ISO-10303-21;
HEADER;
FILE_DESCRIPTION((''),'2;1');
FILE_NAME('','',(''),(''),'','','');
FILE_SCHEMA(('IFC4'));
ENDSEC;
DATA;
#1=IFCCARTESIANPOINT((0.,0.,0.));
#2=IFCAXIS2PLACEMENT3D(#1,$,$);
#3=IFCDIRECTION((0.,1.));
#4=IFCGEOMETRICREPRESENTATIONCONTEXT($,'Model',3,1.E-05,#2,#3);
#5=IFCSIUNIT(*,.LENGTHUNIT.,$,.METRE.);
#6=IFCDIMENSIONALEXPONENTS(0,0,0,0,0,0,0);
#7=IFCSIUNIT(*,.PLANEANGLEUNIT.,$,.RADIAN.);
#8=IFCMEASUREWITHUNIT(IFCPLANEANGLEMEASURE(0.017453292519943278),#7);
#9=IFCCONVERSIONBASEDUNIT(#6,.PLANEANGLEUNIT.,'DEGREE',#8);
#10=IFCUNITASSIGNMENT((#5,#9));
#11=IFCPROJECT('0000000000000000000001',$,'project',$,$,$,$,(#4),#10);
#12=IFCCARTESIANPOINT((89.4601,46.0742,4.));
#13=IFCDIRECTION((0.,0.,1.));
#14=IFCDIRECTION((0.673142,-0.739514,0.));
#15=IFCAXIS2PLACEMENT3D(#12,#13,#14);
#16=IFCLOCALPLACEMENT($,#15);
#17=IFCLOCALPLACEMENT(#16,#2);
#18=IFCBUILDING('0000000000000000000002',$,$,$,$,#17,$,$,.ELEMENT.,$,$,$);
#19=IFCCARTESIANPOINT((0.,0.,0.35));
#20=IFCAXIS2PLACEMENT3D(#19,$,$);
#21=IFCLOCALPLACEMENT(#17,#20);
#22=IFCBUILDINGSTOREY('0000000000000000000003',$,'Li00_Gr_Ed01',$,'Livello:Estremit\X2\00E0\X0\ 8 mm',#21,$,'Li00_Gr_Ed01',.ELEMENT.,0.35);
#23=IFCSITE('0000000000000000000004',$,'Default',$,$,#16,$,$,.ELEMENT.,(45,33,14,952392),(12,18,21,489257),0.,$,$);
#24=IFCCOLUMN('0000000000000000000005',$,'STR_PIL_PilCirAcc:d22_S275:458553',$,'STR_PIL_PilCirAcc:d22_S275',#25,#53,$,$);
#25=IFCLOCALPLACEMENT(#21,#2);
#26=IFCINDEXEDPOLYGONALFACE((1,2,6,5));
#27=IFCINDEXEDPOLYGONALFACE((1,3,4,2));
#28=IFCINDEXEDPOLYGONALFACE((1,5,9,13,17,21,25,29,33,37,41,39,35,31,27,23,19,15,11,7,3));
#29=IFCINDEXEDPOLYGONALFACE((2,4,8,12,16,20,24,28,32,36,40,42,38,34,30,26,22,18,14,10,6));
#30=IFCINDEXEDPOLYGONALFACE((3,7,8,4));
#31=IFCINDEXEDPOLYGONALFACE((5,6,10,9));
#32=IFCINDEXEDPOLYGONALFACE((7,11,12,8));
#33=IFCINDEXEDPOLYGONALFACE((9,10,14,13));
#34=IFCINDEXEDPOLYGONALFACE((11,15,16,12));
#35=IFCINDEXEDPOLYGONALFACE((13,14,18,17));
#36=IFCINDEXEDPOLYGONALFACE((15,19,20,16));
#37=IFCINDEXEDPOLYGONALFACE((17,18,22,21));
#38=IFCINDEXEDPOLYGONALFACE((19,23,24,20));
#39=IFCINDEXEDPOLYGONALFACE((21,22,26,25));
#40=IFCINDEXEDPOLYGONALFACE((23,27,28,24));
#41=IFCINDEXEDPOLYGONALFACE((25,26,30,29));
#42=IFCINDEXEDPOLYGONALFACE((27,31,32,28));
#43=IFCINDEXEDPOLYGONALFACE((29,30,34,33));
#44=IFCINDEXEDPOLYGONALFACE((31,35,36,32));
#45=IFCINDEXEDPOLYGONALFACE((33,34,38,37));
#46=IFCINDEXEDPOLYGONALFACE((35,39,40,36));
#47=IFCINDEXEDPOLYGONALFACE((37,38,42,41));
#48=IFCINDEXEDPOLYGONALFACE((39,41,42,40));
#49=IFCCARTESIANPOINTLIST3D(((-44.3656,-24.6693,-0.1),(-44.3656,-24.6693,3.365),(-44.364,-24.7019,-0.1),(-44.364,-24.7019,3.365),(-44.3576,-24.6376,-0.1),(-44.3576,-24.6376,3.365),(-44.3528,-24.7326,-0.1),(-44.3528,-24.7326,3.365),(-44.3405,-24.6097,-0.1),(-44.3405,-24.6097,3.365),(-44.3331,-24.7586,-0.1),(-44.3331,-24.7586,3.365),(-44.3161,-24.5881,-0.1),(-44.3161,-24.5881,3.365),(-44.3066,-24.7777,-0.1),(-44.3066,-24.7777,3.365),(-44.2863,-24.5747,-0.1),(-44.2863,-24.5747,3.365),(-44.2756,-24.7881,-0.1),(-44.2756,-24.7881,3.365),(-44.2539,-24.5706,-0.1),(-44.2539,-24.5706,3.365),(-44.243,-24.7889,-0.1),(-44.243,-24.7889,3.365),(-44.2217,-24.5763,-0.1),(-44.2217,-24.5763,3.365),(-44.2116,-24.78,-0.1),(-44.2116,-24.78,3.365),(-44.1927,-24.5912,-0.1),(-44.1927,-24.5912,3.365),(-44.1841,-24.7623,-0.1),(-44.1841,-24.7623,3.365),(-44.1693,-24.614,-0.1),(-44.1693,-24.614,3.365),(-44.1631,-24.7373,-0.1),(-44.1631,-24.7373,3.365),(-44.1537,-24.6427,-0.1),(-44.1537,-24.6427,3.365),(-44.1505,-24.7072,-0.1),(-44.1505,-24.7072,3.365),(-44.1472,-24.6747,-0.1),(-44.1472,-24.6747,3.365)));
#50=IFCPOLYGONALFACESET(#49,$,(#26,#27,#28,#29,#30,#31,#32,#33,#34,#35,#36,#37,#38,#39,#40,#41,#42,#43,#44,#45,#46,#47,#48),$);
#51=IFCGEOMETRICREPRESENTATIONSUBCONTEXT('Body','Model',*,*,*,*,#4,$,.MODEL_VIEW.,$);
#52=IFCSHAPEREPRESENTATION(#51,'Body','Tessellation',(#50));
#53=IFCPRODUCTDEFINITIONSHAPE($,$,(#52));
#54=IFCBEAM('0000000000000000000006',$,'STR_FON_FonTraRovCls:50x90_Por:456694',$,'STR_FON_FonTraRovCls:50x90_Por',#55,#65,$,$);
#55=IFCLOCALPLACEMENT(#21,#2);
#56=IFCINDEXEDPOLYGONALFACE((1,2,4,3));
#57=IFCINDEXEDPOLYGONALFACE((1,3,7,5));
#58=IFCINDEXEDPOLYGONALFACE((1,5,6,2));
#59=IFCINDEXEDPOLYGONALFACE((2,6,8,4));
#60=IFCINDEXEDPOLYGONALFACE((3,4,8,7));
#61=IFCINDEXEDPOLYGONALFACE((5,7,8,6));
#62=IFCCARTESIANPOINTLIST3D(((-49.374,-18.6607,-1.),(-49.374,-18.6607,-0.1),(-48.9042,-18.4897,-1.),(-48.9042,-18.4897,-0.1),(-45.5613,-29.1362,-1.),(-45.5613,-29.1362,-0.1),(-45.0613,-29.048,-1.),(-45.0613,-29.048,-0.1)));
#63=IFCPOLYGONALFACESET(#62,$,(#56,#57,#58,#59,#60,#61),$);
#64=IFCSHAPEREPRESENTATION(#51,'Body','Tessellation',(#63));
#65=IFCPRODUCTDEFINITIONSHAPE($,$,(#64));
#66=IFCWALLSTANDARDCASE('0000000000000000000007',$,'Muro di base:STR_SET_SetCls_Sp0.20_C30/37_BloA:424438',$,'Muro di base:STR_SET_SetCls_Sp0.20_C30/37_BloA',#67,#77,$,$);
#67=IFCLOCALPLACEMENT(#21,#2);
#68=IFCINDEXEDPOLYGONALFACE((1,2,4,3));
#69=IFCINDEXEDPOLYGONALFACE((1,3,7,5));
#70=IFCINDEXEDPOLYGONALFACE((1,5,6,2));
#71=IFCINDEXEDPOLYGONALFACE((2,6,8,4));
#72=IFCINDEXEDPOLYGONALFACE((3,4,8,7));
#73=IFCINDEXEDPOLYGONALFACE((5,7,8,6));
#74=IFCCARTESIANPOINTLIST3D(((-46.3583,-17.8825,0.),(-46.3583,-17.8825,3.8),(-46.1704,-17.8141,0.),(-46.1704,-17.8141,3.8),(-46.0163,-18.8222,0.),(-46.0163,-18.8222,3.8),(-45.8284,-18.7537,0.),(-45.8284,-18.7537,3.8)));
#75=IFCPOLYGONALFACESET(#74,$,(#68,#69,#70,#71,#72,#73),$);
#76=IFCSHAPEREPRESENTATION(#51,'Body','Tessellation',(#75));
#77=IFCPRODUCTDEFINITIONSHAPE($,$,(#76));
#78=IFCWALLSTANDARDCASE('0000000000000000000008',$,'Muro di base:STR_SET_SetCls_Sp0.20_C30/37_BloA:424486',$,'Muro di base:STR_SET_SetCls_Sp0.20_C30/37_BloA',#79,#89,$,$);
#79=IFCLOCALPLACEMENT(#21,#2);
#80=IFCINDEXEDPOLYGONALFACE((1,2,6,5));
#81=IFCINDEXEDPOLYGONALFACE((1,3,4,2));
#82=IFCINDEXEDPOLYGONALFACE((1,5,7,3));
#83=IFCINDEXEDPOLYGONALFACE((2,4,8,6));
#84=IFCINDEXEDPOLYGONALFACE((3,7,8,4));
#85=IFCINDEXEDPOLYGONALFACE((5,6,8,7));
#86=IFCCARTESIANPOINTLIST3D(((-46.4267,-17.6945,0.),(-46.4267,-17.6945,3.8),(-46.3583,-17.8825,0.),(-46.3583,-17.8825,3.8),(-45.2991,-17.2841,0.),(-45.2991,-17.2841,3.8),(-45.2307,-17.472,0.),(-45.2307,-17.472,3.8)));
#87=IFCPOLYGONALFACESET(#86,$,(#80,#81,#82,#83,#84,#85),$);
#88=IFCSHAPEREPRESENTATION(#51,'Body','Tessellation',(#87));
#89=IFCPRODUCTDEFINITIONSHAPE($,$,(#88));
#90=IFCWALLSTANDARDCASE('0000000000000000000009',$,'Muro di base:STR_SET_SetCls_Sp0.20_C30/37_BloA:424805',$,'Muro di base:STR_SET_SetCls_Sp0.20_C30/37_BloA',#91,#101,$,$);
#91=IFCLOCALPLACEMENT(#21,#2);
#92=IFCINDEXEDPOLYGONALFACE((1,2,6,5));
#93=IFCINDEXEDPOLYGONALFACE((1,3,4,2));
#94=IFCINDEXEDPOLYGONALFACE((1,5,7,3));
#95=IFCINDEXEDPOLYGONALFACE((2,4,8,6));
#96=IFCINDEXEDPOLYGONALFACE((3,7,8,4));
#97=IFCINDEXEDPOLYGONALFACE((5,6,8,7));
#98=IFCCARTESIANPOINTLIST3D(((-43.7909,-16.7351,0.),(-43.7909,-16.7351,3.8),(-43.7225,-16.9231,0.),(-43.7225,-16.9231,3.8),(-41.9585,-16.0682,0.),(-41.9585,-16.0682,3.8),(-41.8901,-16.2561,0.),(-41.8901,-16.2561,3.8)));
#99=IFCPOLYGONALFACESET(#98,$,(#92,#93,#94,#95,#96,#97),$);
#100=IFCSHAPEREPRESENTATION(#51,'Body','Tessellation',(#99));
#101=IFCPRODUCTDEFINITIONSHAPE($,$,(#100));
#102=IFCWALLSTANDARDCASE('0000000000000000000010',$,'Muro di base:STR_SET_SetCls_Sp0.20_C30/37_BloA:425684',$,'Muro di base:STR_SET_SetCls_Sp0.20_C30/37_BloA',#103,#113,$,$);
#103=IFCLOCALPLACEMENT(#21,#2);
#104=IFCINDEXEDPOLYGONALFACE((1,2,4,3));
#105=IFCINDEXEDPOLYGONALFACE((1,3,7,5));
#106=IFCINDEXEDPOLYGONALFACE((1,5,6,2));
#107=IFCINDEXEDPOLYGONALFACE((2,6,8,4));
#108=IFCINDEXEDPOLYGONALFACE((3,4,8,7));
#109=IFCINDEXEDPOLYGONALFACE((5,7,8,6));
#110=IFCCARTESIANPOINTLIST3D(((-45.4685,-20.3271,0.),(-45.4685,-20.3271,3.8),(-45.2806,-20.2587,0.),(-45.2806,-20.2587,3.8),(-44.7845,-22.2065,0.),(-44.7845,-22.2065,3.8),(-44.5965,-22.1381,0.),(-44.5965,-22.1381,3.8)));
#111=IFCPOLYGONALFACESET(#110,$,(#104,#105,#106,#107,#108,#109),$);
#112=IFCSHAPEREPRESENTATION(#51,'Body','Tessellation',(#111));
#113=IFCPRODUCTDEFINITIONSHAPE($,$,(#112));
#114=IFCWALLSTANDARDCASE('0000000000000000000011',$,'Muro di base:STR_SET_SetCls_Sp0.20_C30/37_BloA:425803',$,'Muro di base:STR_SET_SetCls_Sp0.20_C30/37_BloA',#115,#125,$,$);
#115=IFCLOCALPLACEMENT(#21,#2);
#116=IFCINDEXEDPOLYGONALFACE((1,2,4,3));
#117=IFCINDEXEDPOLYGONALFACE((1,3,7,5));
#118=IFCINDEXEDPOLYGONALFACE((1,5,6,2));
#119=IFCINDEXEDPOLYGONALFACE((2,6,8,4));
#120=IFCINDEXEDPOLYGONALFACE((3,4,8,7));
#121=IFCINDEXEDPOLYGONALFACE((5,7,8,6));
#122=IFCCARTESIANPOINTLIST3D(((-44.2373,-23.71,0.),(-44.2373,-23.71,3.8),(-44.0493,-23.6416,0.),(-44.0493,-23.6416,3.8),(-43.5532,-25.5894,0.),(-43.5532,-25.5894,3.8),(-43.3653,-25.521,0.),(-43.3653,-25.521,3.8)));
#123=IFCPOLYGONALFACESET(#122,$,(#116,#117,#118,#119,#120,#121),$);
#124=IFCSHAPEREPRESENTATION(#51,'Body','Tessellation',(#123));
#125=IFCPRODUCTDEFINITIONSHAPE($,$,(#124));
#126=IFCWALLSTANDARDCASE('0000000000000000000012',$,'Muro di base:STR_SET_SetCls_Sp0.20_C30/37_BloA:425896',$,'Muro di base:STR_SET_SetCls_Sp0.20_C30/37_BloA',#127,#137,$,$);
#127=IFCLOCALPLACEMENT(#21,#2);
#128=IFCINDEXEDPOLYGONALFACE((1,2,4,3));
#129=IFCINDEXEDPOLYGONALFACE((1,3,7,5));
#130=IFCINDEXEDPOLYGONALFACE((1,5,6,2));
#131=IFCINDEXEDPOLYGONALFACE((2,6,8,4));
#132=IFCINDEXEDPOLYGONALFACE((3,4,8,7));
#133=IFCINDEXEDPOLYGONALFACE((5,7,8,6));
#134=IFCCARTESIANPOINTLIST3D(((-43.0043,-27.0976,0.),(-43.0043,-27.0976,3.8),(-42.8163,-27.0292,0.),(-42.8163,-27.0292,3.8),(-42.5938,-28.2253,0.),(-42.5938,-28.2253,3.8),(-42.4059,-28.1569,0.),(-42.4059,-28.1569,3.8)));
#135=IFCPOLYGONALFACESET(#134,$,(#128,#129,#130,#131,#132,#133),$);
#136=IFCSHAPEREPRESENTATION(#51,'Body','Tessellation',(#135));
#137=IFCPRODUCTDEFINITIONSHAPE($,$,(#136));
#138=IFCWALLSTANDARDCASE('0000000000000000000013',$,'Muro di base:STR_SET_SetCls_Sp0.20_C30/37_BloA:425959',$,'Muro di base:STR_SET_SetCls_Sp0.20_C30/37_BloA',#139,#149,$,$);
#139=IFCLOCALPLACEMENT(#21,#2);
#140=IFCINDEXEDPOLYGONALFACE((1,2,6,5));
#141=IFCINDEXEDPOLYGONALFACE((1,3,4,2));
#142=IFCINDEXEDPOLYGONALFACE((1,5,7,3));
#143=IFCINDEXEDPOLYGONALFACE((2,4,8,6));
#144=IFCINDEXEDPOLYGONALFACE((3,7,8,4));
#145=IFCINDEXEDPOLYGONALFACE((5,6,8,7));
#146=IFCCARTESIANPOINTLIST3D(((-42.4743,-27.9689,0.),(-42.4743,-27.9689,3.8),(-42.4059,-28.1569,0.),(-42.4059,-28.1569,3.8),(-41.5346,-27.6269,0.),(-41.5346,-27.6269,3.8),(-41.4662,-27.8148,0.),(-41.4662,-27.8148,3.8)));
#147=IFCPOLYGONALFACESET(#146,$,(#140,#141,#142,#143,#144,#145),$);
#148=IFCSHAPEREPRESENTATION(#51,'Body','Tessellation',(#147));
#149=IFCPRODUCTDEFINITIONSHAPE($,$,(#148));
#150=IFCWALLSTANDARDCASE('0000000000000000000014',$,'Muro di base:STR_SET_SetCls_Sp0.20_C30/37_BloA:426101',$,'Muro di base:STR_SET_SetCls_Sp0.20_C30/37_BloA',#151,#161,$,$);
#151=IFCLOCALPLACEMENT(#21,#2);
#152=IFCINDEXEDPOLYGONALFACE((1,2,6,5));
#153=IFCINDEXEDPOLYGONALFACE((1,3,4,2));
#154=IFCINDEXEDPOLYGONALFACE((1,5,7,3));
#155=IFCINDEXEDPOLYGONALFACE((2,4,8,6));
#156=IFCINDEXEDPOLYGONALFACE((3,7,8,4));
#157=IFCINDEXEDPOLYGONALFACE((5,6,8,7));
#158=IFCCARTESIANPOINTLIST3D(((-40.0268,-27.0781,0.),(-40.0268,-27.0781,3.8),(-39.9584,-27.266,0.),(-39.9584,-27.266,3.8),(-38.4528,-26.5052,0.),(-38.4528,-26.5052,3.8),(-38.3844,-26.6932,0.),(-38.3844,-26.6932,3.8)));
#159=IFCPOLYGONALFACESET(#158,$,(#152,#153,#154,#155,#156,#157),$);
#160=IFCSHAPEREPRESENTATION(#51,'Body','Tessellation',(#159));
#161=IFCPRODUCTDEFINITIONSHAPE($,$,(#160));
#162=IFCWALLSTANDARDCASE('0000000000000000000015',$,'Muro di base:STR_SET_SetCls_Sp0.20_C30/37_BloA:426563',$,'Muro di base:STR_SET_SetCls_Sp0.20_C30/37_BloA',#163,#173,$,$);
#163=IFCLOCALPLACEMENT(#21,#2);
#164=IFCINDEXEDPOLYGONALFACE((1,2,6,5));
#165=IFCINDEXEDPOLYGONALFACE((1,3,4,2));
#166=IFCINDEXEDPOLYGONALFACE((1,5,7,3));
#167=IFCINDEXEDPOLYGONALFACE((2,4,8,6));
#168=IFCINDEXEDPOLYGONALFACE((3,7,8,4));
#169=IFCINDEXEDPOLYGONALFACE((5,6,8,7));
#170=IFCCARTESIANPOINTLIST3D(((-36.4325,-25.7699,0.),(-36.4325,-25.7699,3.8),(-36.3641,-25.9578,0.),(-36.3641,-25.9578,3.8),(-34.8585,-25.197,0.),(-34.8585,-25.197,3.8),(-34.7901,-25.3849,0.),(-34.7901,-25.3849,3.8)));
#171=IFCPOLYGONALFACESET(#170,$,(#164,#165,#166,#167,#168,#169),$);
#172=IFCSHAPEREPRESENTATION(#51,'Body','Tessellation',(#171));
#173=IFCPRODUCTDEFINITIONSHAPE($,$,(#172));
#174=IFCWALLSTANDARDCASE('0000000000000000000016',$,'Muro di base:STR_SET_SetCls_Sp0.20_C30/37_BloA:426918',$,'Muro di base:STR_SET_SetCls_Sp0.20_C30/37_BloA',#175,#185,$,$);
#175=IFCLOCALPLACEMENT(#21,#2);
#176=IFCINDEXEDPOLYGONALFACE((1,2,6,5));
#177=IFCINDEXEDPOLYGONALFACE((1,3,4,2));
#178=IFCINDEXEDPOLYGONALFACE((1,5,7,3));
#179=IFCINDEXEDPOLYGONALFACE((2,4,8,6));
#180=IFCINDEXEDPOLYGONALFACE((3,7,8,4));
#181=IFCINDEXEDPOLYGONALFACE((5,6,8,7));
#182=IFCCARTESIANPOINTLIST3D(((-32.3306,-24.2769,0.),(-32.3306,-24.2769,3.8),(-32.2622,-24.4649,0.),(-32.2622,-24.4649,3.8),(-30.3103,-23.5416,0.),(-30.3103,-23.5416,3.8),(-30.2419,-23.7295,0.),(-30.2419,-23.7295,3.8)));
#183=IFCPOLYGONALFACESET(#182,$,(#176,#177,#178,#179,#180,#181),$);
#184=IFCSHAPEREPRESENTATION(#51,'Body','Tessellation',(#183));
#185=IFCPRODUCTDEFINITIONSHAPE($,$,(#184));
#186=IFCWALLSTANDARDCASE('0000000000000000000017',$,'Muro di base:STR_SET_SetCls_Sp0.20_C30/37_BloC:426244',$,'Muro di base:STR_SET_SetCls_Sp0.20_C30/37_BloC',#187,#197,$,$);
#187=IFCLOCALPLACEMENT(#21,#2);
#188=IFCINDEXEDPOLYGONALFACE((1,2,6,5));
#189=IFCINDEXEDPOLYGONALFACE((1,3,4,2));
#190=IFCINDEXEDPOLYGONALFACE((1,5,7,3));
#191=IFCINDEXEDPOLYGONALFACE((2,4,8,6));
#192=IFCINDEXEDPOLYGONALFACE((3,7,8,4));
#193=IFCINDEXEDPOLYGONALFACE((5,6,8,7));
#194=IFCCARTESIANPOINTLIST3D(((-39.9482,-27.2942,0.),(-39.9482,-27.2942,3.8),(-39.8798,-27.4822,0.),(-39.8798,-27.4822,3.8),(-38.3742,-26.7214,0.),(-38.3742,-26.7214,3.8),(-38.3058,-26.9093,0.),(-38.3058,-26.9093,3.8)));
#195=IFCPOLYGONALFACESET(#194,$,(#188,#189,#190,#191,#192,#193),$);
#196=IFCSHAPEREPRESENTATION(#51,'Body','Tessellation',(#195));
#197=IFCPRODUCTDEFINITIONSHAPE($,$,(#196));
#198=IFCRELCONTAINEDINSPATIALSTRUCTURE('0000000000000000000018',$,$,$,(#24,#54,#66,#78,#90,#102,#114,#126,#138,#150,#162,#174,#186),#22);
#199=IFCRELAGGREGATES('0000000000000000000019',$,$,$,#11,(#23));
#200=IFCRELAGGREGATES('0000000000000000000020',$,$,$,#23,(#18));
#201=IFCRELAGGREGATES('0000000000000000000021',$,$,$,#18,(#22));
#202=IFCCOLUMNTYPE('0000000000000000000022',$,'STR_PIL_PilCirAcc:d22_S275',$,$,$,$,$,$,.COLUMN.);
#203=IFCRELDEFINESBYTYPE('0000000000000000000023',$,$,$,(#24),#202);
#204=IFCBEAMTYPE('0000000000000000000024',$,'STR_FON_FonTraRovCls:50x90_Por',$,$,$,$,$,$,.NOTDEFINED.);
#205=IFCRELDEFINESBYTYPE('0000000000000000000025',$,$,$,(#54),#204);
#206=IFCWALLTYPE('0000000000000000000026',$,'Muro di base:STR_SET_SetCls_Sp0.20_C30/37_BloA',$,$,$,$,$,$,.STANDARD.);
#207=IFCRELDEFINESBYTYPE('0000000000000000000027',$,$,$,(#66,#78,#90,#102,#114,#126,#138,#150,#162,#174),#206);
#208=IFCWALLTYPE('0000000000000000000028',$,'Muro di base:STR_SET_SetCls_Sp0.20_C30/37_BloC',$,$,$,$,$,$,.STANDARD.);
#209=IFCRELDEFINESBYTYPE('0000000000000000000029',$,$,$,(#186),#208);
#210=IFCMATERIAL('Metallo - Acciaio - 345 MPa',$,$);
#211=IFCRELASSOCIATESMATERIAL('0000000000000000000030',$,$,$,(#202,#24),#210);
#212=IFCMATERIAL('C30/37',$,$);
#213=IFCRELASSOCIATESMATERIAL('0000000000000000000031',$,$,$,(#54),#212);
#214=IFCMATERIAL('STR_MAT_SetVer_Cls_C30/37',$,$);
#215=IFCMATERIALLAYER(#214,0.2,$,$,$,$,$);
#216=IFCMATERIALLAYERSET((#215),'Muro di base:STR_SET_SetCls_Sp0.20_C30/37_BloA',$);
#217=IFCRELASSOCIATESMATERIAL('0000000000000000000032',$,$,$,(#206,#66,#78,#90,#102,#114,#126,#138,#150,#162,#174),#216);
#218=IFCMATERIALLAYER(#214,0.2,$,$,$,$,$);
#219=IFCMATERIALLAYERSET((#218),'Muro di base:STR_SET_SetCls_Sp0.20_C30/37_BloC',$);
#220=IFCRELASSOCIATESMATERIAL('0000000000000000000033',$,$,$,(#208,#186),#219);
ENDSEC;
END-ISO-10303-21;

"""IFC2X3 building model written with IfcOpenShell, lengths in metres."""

from ifc_helpers import new_model, entity, si_unit, converted_unit, direction, frame, frame_2d, origin, place, context, subcontext, project, spatial, rectangle, circle, extrude, clip, halfspace, source, transform, mapped, material, layer, layer_set, layer_usage, type_object, type_shapes, element, save


model = new_model("IFC2X3")

# Units and contexts
model_context = context("Model", 3, precision=1e-05, world=origin(), true_north=direction((0.0, 1.0)))
body_context = subcontext(model_context, "Body", "Model", "MODEL_VIEW")
ifc_project = project(units=[si_unit("LENGTHUNIT", "METRE"), converted_unit("PLANEANGLEUNIT", "DEGREE", entity("IfcPlaneAngleMeasure", 0.017453292519943278), si_unit("PLANEANGLEUNIT", "RADIAN"), dimensions=[0, 0, 0, 0, 0, 0, 0])], contexts=[model_context])

# Site, building, storey
site_placement = place(None, frame((89.4601, 46.0742, 4.0), z_axis=(0.0, 0.0, 1.0), x_axis=(0.673142, -0.739514, 0.0)))
site = spatial("IfcSite", under=ifc_project, at=site_placement, Name="Default", CompositionType="ELEMENT", RefLatitude=(45, 33, 14, 952392), RefLongitude=(12, 18, 21, 489257), RefElevation=0.0)
building_placement = place(site_placement, origin())
building = spatial("IfcBuilding", under=site, at=building_placement, CompositionType="ELEMENT")
storey_placement = place(building_placement, frame((0.0, 0.0, 0.35)))
storey = spatial("IfcBuildingStorey", under=building, at=storey_placement, Name="Li00_Gr_Ed01", ObjectType="Livello:Estremità 8 mm", LongName="Li00_Gr_Ed01", CompositionType="ELEMENT", Elevation=0.35)

# Column
ifc_material_1 = material(Name="Metallo - Acciaio - 345 MPa")
column_type = type_object("IfcColumnType", Name="STR_PIL_PilCirAcc:d22_S275", PredefinedType="COLUMN", material=ifc_material_1)
shared_shape = source(origin(), body_context, "Body", "SweptSolid", [
    extrude(circle(Radius=0.1096, at=frame_2d((0.0, 0.0), x_axis=(1.0, 0.0))), frame((0.0, 0.0, 0.25)), (0.0, 0.0, 1.0), 3.465),
])
type_shapes(column_type, [shared_shape])
column_placement = place(storey_placement, frame((-44.2566, -24.6802, -0.35), z_axis=(0.0, 0.0, 1.0), x_axis=(0.939693, 0.34202, 0.0)))
element("IfcColumn", 1, at=column_placement, inside=storey, type_object=column_type, material=ifc_material_1, Name="STR_PIL_PilCirAcc:d22_S275:458553", ObjectType="STR_PIL_PilCirAcc:d22_S275", context=body_context, shape_type="MappedRepresentation", body=[
    mapped(shared_shape, transform((0.0, 0.0, 0.0), scale=1.0)),
])

# Beam
ifc_material_2 = material(Name="C30/37")
beam_type_1 = type_object("IfcBeamType", Name="STR_FON_FonTraRovCls:50x90_Por", PredefinedType="NOTDEFINED")
beam_1_placement = place(storey_placement, frame((-49.1348, -18.587, -0.1), z_axis=(0.0, 0.0, 1.0), x_axis=(0.34202, -0.939693, 0.0)))
element("IfcBeam", 2, at=beam_1_placement, inside=storey, type_object=beam_type_1, material=ifc_material_2, Name="STR_FON_FonTraRovCls:50x90_Por:456694", ObjectType="STR_FON_FonTraRovCls:50x90_Por", context=body_context, shape_type="SweptSolid", body=[
    clip(extrude(rectangle(XDim=0.9, YDim=0.5, at=frame_2d((0.0, 0.0), x_axis=(1.0, 0.0))), frame((-0.0125, 0.0, -0.45), z_axis=(1.0, 0.0, 0.0), x_axis=(0.0, 0.0, -1.0)), (0.0, 0.0, 1.0), 11.2359), halfspace(frame((11.1352, -0.25, 0.0), z_axis=(0.984808, -0.173648, 0.0), x_axis=(0.173648, 0.984808, 0.0)), False)),
])

# Walls
ifc_material_3 = material(Name="STR_MAT_SetVer_Cls_C30/37")
ifc_layer_1 = layer(ifc_material_3, 0.2)
ifc_layer_set_1 = layer_set([ifc_layer_1], Name="Muro di base:STR_SET_SetCls_Sp0.20_C30/37_BloA")
ifc_layer_usage_1 = layer_usage(ifc_layer_set_1, "AXIS2", "NEGATIVE", 0.1)
wall_type_1 = type_object("IfcWallType", Name="Muro di base:STR_SET_SetCls_Sp0.20_C30/37_BloA", PredefinedType="STANDARD", material=ifc_layer_set_1)
wall_1_placement = place(storey_placement, frame((-45.9223, -18.788, 0.0), z_axis=(0.0, 0.0, 1.0), x_axis=(-0.34202, 0.939693, 0.0)))
element("IfcWallStandardCase", 3, at=wall_1_placement, inside=storey, type_object=wall_type_1, material=ifc_layer_usage_1, Name="Muro di base:STR_SET_SetCls_Sp0.20_C30/37_BloA:424438", ObjectType="Muro di base:STR_SET_SetCls_Sp0.20_C30/37_BloA", context=body_context, shape_type="SweptSolid", body=[
    extrude(rectangle(XDim=1.0, YDim=0.2, at=frame_2d((0.5, 0.0), x_axis=(-1.0, 0.0))), origin(), (0.0, 0.0, 1.0), 3.8),
])
wall_2_placement = place(storey_placement, frame((-45.2649, -17.3781, 0.0), z_axis=(0.0, 0.0, 1.0), x_axis=(-0.939693, -0.34202, 0.0)))
element("IfcWallStandardCase", 4, at=wall_2_placement, inside=storey, type_object=wall_type_1, material=ifc_layer_usage_1, Name="Muro di base:STR_SET_SetCls_Sp0.20_C30/37_BloA:424486", ObjectType="Muro di base:STR_SET_SetCls_Sp0.20_C30/37_BloA", context=body_context, shape_type="SweptSolid", body=[
    extrude(rectangle(XDim=1.2, YDim=0.2, at=frame_2d((0.6, 0.0), x_axis=(-1.0, 0.0))), origin(), (0.0, 0.0, 1.0), 3.8),
])
wall_3_placement = place(storey_placement, frame((-43.7567, -16.8291, 0.0), z_axis=(0.0, 0.0, 1.0), x_axis=(0.939693, 0.34202, 0.0)))
element("IfcWallStandardCase", 5, at=wall_3_placement, inside=storey, type_object=wall_type_1, material=ifc_layer_usage_1, Name="Muro di base:STR_SET_SetCls_Sp0.20_C30/37_BloA:424805", ObjectType="Muro di base:STR_SET_SetCls_Sp0.20_C30/37_BloA", context=body_context, shape_type="SweptSolid", body=[
    extrude(rectangle(XDim=1.95, YDim=0.2, at=frame_2d((0.975, 0.0), x_axis=(-1.0, 0.0))), origin(), (0.0, 0.0, 1.0), 3.8),
])
wall_4_placement = place(storey_placement, frame((-45.3746, -20.2929, 0.0), z_axis=(0.0, 0.0, 1.0), x_axis=(0.34202, -0.939693, 0.0)))
element("IfcWallStandardCase", 6, at=wall_4_placement, inside=storey, type_object=wall_type_1, material=ifc_layer_usage_1, Name="Muro di base:STR_SET_SetCls_Sp0.20_C30/37_BloA:425684", ObjectType="Muro di base:STR_SET_SetCls_Sp0.20_C30/37_BloA", context=body_context, shape_type="SweptSolid", body=[
    extrude(rectangle(XDim=2.0, YDim=0.2, at=frame_2d((1.0, 0.0), x_axis=(-1.0, 0.0))), origin(), (0.0, 0.0, 1.0), 3.8),
])
wall_5_placement = place(storey_placement, frame((-44.1433, -23.6758, 0.0), z_axis=(0.0, 0.0, 1.0), x_axis=(0.34202, -0.939693, 0.0)))
element("IfcWallStandardCase", 7, at=wall_5_placement, inside=storey, type_object=wall_type_1, material=ifc_layer_usage_1, Name="Muro di base:STR_SET_SetCls_Sp0.20_C30/37_BloA:425803", ObjectType="Muro di base:STR_SET_SetCls_Sp0.20_C30/37_BloA", context=body_context, shape_type="SweptSolid", body=[
    extrude(rectangle(XDim=2.0, YDim=0.2, at=frame_2d((1.0, 0.0), x_axis=(-1.0, 0.0))), origin(), (0.0, 0.0, 1.0), 3.8),
])
wall_6_placement = place(storey_placement, frame((-42.9103, -27.0634, 0.0), z_axis=(0.0, 0.0, 1.0), x_axis=(0.34202, -0.939693, 0.0)))
element("IfcWallStandardCase", 8, at=wall_6_placement, inside=storey, type_object=wall_type_1, material=ifc_layer_usage_1, Name="Muro di base:STR_SET_SetCls_Sp0.20_C30/37_BloA:425896", ObjectType="Muro di base:STR_SET_SetCls_Sp0.20_C30/37_BloA", context=body_context, shape_type="SweptSolid", body=[
    extrude(rectangle(XDim=1.2, YDim=0.2, at=frame_2d((0.6, 0.0), x_axis=(-1.0, 0.0))), origin(), (0.0, 0.0, 1.0), 3.8),
])
wall_7_placement = place(storey_placement, frame((-42.4401, -28.0629, 0.0), z_axis=(0.0, 0.0, 1.0), x_axis=(0.939693, 0.34202, 0.0)))
element("IfcWallStandardCase", 9, at=wall_7_placement, inside=storey, type_object=wall_type_1, material=ifc_layer_usage_1, Name="Muro di base:STR_SET_SetCls_Sp0.20_C30/37_BloA:425959", ObjectType="Muro di base:STR_SET_SetCls_Sp0.20_C30/37_BloA", context=body_context, shape_type="SweptSolid", body=[
    extrude(rectangle(XDim=1.0, YDim=0.2, at=frame_2d((0.5, 0.0), x_axis=(-1.0, 0.0))), origin(), (0.0, 0.0, 1.0), 3.8),
])
for number, where, z_axis, x_axis, name in (
    (10, (-39.9926, -27.1721, 0.0), (0.0, 0.0, 1.0), (0.939693, 0.34202, 0.0), "Muro di base:STR_SET_SetCls_Sp0.20_C30/37_BloA:426101"),
    (11, (-36.3983, -25.8638, 0.0), (0.0, 0.0, 1.0), (0.939693, 0.34202, 0.0), "Muro di base:STR_SET_SetCls_Sp0.20_C30/37_BloA:426563"),
):
    element("IfcWallStandardCase", number, at=place(storey_placement, frame(where, z_axis=z_axis, x_axis=x_axis)), inside=storey, type_object=wall_type_1, material=ifc_layer_usage_1, Name=name, ObjectType="Muro di base:STR_SET_SetCls_Sp0.20_C30/37_BloA", context=body_context, shape_type="SweptSolid", body=[
        extrude(rectangle(XDim=1.675, YDim=0.2, at=frame_2d((0.8375, 0.0), x_axis=(-1.0, 0.0))), origin(), (0.0, 0.0, 1.0), 3.8),
    ])
wall_8_placement = place(storey_placement, frame((-32.2964, -24.3709, 0.0), z_axis=(0.0, 0.0, 1.0), x_axis=(0.939693, 0.34202, 0.0)))
element("IfcWallStandardCase", 12, at=wall_8_placement, inside=storey, type_object=wall_type_1, material=ifc_layer_usage_1, Name="Muro di base:STR_SET_SetCls_Sp0.20_C30/37_BloA:426918", ObjectType="Muro di base:STR_SET_SetCls_Sp0.20_C30/37_BloA", context=body_context, shape_type="SweptSolid", body=[
    extrude(rectangle(XDim=2.15, YDim=0.2, at=frame_2d((1.075, 0.0), x_axis=(-1.0, 0.0))), origin(), (0.0, 0.0, 1.0), 3.8),
])
ifc_layer_2 = layer(ifc_material_3, 0.2)
ifc_layer_set_2 = layer_set([ifc_layer_2], Name="Muro di base:STR_SET_SetCls_Sp0.20_C30/37_BloC")
ifc_layer_usage_2 = layer_usage(ifc_layer_set_2, "AXIS2", "NEGATIVE", 0.1)
wall_type_2 = type_object("IfcWallType", Name="Muro di base:STR_SET_SetCls_Sp0.20_C30/37_BloC", PredefinedType="STANDARD", material=ifc_layer_set_2)
wall_9_placement = place(storey_placement, frame((-39.914, -27.3882, 0.0), z_axis=(0.0, 0.0, 1.0), x_axis=(0.939693, 0.34202, 0.0)))
element("IfcWallStandardCase", 13, at=wall_9_placement, inside=storey, type_object=wall_type_2, material=ifc_layer_usage_2, Name="Muro di base:STR_SET_SetCls_Sp0.20_C30/37_BloC:426244", ObjectType="Muro di base:STR_SET_SetCls_Sp0.20_C30/37_BloC", context=body_context, shape_type="SweptSolid", body=[
    extrude(rectangle(XDim=1.675, YDim=0.2, at=frame_2d((0.8375, 0.0), x_axis=(-1.0, 0.0))), origin(), (0.0, 0.0, 1.0), 3.8),
])

save(model, "model.ifc")
